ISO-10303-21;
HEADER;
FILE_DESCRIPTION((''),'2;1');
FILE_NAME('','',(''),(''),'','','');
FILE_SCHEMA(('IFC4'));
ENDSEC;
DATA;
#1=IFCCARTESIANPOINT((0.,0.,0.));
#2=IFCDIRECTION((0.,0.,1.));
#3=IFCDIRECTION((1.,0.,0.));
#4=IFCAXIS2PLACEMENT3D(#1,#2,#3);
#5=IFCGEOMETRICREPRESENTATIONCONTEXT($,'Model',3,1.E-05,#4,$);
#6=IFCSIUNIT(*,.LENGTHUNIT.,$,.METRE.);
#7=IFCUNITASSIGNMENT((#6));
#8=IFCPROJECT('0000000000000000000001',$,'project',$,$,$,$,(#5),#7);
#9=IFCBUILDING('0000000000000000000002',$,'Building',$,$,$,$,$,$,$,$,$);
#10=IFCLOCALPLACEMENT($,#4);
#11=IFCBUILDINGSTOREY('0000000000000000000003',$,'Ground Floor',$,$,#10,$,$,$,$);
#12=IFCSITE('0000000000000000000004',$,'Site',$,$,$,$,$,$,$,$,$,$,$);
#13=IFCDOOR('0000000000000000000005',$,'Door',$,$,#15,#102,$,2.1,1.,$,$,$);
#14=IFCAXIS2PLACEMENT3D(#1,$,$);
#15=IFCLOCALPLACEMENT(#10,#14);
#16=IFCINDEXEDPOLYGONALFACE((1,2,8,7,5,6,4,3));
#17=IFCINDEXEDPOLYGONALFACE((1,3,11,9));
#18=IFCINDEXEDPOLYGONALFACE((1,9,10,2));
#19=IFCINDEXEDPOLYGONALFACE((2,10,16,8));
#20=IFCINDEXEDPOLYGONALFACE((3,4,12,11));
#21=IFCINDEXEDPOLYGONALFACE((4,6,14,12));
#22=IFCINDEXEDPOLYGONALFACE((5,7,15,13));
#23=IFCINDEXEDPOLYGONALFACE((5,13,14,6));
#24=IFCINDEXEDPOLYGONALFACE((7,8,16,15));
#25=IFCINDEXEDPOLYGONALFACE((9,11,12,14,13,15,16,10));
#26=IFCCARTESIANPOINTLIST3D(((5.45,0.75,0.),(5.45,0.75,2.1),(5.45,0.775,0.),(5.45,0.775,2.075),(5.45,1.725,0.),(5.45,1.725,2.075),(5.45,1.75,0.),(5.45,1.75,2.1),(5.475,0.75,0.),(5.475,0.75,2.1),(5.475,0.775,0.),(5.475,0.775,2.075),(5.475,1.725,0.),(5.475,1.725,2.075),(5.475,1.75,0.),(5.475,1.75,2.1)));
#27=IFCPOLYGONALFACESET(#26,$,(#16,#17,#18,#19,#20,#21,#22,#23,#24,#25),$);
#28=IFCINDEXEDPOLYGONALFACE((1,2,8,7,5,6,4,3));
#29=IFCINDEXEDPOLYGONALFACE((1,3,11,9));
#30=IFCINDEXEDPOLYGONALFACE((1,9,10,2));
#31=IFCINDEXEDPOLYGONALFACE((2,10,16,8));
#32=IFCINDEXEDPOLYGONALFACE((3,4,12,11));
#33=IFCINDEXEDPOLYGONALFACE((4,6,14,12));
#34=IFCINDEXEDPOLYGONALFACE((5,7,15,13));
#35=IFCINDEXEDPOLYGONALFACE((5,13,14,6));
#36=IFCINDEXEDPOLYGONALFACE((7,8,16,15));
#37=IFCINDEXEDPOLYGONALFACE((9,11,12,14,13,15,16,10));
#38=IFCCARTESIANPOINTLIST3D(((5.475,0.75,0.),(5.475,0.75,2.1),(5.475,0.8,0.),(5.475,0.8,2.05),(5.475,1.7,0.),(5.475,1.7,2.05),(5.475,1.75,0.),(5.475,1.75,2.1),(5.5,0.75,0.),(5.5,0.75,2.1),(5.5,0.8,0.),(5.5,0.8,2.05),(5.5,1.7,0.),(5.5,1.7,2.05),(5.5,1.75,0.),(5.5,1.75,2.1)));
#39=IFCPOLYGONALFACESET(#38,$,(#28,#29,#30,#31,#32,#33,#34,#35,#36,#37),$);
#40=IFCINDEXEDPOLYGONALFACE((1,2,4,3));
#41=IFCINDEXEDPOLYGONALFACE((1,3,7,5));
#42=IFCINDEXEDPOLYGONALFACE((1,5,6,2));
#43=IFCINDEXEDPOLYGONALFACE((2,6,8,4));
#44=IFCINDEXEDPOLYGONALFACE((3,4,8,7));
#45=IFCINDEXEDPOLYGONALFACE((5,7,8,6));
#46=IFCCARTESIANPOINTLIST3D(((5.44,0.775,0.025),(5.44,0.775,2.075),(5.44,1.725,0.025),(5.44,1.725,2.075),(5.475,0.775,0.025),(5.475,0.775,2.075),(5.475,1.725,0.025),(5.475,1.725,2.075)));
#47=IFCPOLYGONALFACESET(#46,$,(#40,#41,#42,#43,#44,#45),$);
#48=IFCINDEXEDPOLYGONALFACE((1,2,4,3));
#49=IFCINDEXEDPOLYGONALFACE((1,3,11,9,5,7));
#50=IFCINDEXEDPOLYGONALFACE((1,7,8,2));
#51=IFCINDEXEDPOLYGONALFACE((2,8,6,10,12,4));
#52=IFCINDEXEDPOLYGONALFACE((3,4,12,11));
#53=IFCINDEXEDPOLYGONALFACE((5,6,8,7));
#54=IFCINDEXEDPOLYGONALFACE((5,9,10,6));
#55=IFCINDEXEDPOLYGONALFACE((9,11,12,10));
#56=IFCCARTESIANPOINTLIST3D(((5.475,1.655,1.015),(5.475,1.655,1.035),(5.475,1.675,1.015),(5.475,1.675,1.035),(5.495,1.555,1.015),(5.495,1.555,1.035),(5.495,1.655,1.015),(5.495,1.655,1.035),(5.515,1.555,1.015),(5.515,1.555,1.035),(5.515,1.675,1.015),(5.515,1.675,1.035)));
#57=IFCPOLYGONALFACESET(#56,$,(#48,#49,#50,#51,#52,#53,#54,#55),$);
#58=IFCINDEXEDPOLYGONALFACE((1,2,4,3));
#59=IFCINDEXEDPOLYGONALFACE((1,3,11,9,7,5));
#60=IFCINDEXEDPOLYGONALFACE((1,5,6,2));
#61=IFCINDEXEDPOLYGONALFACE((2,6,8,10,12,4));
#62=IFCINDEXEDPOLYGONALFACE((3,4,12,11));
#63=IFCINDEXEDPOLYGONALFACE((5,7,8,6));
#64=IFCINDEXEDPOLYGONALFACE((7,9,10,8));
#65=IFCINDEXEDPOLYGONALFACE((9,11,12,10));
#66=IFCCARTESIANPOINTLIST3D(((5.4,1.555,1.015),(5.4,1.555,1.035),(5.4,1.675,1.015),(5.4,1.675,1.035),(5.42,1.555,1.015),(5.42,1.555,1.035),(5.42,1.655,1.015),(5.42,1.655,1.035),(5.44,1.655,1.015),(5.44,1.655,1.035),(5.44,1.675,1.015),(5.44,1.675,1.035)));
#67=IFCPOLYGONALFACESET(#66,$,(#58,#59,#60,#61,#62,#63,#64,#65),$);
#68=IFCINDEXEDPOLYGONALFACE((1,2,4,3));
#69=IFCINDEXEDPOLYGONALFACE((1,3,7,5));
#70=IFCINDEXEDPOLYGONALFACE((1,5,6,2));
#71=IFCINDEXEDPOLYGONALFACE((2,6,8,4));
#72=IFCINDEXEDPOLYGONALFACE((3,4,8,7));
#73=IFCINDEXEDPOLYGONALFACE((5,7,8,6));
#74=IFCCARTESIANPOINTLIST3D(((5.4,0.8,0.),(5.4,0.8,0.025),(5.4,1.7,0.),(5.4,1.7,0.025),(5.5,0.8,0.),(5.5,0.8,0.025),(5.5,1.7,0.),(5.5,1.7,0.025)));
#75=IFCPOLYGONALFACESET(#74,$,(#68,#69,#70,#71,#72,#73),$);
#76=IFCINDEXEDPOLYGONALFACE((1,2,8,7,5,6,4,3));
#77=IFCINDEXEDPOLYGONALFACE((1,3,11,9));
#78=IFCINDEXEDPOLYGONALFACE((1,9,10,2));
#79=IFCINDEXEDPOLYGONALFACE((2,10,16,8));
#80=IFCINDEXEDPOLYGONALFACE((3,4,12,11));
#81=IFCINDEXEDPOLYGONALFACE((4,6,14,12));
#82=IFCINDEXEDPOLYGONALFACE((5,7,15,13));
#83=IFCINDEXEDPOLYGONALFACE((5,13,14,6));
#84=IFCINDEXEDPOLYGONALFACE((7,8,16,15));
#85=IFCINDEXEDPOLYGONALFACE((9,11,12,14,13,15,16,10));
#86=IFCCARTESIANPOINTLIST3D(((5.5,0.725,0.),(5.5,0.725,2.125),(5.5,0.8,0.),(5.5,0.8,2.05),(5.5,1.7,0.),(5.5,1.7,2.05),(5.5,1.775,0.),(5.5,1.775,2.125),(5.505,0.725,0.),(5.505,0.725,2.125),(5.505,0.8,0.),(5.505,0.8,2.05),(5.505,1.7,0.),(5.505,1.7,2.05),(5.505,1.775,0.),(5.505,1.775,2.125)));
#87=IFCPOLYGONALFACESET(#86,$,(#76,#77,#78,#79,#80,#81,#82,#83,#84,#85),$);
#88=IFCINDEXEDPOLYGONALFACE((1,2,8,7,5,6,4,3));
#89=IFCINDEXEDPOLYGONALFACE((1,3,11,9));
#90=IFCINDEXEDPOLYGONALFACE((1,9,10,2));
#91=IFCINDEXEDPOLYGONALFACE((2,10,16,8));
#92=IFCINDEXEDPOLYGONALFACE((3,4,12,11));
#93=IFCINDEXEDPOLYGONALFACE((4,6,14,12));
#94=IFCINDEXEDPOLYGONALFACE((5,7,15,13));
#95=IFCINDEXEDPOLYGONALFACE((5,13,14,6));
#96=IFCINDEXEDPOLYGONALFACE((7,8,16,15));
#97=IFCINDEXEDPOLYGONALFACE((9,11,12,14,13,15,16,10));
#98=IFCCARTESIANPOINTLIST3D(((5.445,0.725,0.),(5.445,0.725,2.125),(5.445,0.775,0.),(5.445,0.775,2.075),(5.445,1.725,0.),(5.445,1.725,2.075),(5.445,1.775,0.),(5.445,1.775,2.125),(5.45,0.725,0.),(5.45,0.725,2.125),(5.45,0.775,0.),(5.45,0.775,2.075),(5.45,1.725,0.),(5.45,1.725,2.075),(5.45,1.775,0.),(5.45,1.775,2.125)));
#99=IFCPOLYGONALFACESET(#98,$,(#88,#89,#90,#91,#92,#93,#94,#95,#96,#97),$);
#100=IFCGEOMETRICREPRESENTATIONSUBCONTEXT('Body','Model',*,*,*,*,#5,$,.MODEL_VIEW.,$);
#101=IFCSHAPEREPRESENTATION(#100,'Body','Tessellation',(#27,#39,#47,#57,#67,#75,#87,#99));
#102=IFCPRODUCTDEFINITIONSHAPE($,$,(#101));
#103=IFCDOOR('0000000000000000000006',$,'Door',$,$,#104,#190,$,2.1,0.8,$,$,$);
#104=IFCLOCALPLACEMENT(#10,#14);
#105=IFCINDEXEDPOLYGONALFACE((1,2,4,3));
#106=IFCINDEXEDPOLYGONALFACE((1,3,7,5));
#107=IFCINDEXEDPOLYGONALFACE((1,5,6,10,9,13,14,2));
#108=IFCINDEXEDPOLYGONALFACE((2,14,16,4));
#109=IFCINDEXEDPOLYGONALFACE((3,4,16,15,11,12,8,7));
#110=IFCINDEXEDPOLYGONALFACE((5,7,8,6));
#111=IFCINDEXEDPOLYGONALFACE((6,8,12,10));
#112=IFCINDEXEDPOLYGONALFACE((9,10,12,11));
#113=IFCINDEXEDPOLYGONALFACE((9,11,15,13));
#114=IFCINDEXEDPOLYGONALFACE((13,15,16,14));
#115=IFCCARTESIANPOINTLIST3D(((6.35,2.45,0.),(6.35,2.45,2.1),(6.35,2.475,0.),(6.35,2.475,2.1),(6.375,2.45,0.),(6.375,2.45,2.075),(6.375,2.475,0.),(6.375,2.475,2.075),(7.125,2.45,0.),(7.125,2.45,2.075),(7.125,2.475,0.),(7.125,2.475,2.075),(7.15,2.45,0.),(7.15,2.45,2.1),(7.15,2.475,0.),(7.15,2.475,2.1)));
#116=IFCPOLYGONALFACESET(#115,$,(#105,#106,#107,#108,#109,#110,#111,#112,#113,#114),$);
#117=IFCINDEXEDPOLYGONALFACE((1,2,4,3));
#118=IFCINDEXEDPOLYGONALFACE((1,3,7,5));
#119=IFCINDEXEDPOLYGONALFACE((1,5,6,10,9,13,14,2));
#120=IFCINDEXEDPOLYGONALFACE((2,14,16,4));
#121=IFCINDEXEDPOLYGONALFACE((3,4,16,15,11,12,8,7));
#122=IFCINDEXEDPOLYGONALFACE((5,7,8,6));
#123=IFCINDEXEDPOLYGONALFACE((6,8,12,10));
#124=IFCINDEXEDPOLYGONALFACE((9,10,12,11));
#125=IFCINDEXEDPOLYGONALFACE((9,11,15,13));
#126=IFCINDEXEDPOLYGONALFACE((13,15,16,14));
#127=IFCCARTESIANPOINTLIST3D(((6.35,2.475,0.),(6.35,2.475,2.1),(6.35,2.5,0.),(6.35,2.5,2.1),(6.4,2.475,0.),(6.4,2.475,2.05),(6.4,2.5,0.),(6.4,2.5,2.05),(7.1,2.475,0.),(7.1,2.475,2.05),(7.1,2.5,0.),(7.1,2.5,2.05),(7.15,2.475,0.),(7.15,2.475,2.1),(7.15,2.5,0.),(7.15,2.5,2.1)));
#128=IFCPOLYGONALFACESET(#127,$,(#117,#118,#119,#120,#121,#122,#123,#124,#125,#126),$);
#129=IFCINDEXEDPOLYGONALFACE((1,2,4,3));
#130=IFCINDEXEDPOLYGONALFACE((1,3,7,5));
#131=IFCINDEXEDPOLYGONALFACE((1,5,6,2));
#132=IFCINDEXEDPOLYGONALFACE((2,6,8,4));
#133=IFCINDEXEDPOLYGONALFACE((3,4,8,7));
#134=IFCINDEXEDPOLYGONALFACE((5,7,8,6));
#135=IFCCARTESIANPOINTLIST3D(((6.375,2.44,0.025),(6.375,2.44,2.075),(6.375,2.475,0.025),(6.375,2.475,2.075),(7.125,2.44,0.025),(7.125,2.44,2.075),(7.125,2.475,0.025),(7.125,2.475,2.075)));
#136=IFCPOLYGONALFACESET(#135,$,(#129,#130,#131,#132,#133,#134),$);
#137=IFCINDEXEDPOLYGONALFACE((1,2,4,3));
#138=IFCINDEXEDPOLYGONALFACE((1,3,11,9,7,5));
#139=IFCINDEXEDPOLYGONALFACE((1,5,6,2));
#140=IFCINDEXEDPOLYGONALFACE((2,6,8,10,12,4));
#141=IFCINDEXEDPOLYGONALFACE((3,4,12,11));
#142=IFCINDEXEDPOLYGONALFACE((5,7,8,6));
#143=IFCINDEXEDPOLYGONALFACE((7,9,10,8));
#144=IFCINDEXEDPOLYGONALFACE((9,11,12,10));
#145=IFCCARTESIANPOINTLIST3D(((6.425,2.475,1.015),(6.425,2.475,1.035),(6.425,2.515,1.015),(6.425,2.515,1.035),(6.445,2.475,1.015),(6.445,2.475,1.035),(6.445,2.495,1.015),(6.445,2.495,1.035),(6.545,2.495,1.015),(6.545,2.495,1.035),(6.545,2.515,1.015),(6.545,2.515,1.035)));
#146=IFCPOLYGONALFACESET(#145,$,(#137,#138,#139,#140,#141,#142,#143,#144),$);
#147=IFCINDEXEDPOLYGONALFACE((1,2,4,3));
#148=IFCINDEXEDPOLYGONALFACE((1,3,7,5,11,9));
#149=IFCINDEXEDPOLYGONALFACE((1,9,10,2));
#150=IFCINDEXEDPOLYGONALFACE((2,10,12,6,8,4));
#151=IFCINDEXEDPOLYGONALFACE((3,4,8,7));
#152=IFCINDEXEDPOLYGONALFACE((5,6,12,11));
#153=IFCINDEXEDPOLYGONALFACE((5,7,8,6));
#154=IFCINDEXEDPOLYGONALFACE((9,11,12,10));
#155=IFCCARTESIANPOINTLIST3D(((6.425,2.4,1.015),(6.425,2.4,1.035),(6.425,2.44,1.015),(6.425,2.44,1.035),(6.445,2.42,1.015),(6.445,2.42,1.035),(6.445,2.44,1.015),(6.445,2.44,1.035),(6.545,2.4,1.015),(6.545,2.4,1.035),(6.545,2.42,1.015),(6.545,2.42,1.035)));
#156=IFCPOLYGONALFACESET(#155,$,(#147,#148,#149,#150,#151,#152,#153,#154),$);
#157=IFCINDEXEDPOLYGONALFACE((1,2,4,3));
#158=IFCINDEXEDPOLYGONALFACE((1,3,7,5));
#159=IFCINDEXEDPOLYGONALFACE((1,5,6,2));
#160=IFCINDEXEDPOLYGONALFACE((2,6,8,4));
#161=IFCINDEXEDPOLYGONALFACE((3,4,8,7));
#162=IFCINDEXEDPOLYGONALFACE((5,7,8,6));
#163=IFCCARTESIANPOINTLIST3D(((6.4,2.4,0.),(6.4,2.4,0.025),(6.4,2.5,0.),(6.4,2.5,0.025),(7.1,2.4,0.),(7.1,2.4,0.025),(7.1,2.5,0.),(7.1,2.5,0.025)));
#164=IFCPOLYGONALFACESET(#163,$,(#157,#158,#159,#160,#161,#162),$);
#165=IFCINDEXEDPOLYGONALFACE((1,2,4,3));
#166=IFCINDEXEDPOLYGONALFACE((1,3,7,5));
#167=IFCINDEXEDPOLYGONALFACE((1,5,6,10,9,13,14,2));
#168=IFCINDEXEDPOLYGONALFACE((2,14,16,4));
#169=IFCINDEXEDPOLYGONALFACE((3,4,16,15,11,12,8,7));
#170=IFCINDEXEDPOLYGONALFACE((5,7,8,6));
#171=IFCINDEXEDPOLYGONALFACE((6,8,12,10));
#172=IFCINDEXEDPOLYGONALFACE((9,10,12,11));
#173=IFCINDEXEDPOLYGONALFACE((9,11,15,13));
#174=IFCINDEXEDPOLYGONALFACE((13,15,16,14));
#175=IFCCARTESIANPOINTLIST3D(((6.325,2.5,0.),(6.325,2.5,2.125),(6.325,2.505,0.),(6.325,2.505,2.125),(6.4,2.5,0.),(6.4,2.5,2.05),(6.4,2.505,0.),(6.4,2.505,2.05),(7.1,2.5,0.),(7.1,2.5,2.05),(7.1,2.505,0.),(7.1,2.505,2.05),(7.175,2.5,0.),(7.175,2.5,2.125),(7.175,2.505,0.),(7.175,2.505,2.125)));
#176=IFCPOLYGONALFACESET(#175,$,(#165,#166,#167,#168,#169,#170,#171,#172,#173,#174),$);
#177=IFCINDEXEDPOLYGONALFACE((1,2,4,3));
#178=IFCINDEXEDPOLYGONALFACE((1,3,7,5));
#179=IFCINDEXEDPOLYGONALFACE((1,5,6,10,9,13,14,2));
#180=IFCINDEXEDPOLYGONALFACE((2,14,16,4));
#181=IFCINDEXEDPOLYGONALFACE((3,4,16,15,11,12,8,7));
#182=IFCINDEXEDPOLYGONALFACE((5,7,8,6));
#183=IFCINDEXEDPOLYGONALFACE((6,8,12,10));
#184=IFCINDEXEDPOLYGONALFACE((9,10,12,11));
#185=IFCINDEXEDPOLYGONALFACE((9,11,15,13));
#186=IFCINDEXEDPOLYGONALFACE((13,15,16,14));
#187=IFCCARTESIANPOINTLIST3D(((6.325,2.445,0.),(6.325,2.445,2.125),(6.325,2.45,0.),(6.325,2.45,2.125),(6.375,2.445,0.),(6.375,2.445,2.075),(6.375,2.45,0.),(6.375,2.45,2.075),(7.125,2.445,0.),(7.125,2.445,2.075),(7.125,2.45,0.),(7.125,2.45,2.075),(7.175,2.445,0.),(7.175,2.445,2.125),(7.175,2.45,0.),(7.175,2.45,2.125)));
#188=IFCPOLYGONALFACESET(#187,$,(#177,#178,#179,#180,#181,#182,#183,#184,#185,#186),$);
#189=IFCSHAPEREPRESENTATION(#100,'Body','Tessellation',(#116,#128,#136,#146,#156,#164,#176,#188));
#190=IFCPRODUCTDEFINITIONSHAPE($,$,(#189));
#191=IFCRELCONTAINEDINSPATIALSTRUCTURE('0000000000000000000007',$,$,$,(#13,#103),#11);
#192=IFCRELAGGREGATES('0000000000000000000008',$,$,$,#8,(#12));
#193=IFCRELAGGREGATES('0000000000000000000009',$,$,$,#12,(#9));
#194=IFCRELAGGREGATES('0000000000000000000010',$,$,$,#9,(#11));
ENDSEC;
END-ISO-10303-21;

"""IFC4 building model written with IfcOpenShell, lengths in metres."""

from ifc_helpers import new_model, si_unit, frame, origin_with_axes, place, context, subcontext, project, spatial, line, indexed_curve, outline, extrude, element, save


model = new_model("IFC4")

# Units and contexts
model_context = context("Model", 3, precision=1e-05, world=origin_with_axes())
body_context = subcontext(model_context, "Body", "Model", "MODEL_VIEW")
ifc_project = project(units=[si_unit("LENGTHUNIT", "METRE")], contexts=[model_context])

# Site, building, storey
site = spatial("IfcSite", under=ifc_project, Name="Site")
building = spatial("IfcBuilding", under=site, Name="Building")
storey_placement = place(None, origin_with_axes())
storey = spatial("IfcBuildingStorey", under=building, at=storey_placement, Name="Ground Floor")

# Doors
door_1_placement = place(storey_placement, frame((5.5, 0.75, 0.0), z_axis=(0.0, 0.0, 1.0), x_axis=(0.0, 1.0, 0.0)))
element("IfcDoor", 1, at=door_1_placement, inside=storey, Name="Door", OverallHeight=2.1, OverallWidth=1.0, context=body_context, shape_type="SweptSolid", body=[
    extrude(outline(indexed_curve([(0.0, 0.0), (0.0, 2.1), (1.0, 2.1), (1.0, 0.0), (0.975, 0.0), (0.975, 2.075), (0.025, 2.075), (0.025, 0.0)], segments=[line(1, 2, 3, 4, 5, 6, 7, 8, 1)])), frame((0.0, 0.025, 0.0), z_axis=(0.0, -1.0, 0.0), x_axis=(1.0, 0.0, 0.0)), (0.0, 0.0, -1.0), 0.025),
    extrude(outline(indexed_curve([(0.0, 0.0), (0.0, 2.1), (1.0, 2.1), (1.0, 0.0), (0.95, 0.0), (0.95, 2.05), (0.05, 2.05), (0.05, 0.0)], segments=[line(1, 2, 3, 4, 5, 6, 7, 8, 1)])), frame((0.0, 0.0, 0.0), z_axis=(0.0, -1.0, 0.0), x_axis=(1.0, 0.0, 0.0)), (0.0, 0.0, -1.0), 0.025),
    extrude(outline(indexed_curve([(0.0, 0.0), (0.95, 0.0), (0.95, 0.035), (0.0, 0.035)], segments=[line(1, 2, 3, 4, 1)])), frame((0.025, 0.025, 0.025), z_axis=(0.0, 0.0, 1.0), x_axis=(1.0, 0.0, 0.0)), (0.0, 0.0, 1.0), 2.05),
    extrude(outline(indexed_curve([(0.0, 0.0), (0.0, -0.04), (-0.12, -0.04), (-0.12, -0.02), (-0.02, -0.02), (-0.02, 0.0)], segments=[line(1, 2, 3, 4, 5, 6, 1)])), frame((0.925, 0.025, 1.015), z_axis=(0.0, 0.0, 1.0), x_axis=(1.0, 0.0, 0.0)), (0.0, 0.0, 1.0), 0.02),
    extrude(outline(indexed_curve([(0.0, 0.0), (0.0, 0.04), (-0.12, 0.04), (-0.12, 0.02), (-0.02, 0.02), (-0.02, 0.0)], segments=[line(1, 2, 3, 4, 5, 6, 1)])), frame((0.925, 0.06, 1.015), z_axis=(0.0, 0.0, 1.0), x_axis=(1.0, 0.0, 0.0)), (0.0, 0.0, 1.0), 0.02),
    extrude(outline(indexed_curve([(0.0, 0.0), (0.9, 0.0), (0.9, 0.1), (0.0, 0.1)], segments=[line(1, 2, 3, 4, 1)])), frame((0.05, 0.0, 0.0), z_axis=(0.0, 0.0, 1.0), x_axis=(1.0, 0.0, 0.0)), (0.0, 0.0, 1.0), 0.025),
    extrude(outline(indexed_curve([(0.0, 0.0), (0.0, 2.125), (1.05, 2.125), (1.05, 0.0), (0.975, 0.0), (0.975, 2.05), (0.075, 2.05), (0.075, 0.0)], segments=[line(1, 2, 3, 4, 5, 6, 7, 8, 1)])), frame((-0.025, -0.005, 0.0), z_axis=(0.0, -1.0, 0.0), x_axis=(1.0, 0.0, 0.0)), (0.0, 0.0, -1.0), 0.005),
    extrude(outline(indexed_curve([(0.0, 0.0), (0.0, 2.125), (1.05, 2.125), (1.05, 0.0), (1.0, 0.0), (1.0, 2.075), (0.05, 2.075), (0.05, 0.0)], segments=[line(1, 2, 3, 4, 5, 6, 7, 8, 1)])), frame((-0.025, 0.05, 0.0), z_axis=(0.0, -1.0, 0.0), x_axis=(1.0, 0.0, 0.0)), (0.0, 0.0, -1.0), 0.005),
])
door_2_placement = place(storey_placement, frame((7.15, 2.5, 0.0), z_axis=(0.0, 0.0, 1.0), x_axis=(-1.0, 0.0, 0.0)))
element("IfcDoor", 2, at=door_2_placement, inside=storey, Name="Door", OverallHeight=2.1, OverallWidth=0.8, context=body_context, shape_type="SweptSolid", body=[
    extrude(outline(indexed_curve([(0.0, 0.0), (0.0, 2.1), (0.8, 2.1), (0.8, 0.0), (0.775, 0.0), (0.775, 2.075), (0.025, 2.075), (0.025, 0.0)], segments=[line(1, 2, 3, 4, 5, 6, 7, 8, 1)])), frame((0.0, 0.025, 0.0), z_axis=(0.0, -1.0, 0.0), x_axis=(1.0, 0.0, 0.0)), (0.0, 0.0, -1.0), 0.025),
    extrude(outline(indexed_curve([(0.0, 0.0), (0.0, 2.1), (0.8, 2.1), (0.8, 0.0), (0.75, 0.0), (0.75, 2.05), (0.05, 2.05), (0.05, 0.0)], segments=[line(1, 2, 3, 4, 5, 6, 7, 8, 1)])), frame((0.0, 0.0, 0.0), z_axis=(0.0, -1.0, 0.0), x_axis=(1.0, 0.0, 0.0)), (0.0, 0.0, -1.0), 0.025),
    extrude(outline(indexed_curve([(0.0, 0.0), (0.75, 0.0), (0.75, 0.035), (0.0, 0.035)], segments=[line(1, 2, 3, 4, 1)])), frame((0.025, 0.025, 0.025), z_axis=(0.0, 0.0, 1.0), x_axis=(1.0, 0.0, 0.0)), (0.0, 0.0, 1.0), 2.05),
    extrude(outline(indexed_curve([(0.0, 0.0), (0.0, -0.04), (-0.12, -0.04), (-0.12, -0.02), (-0.02, -0.02), (-0.02, 0.0)], segments=[line(1, 2, 3, 4, 5, 6, 1)])), frame((0.725, 0.025, 1.015), z_axis=(0.0, 0.0, 1.0), x_axis=(1.0, 0.0, 0.0)), (0.0, 0.0, 1.0), 0.02),
    extrude(outline(indexed_curve([(0.0, 0.0), (0.0, 0.04), (-0.12, 0.04), (-0.12, 0.02), (-0.02, 0.02), (-0.02, 0.0)], segments=[line(1, 2, 3, 4, 5, 6, 1)])), frame((0.725, 0.06, 1.015), z_axis=(0.0, 0.0, 1.0), x_axis=(1.0, 0.0, 0.0)), (0.0, 0.0, 1.0), 0.02),
    extrude(outline(indexed_curve([(0.0, 0.0), (0.7, 0.0), (0.7, 0.1), (0.0, 0.1)], segments=[line(1, 2, 3, 4, 1)])), frame((0.05, 0.0, 0.0), z_axis=(0.0, 0.0, 1.0), x_axis=(1.0, 0.0, 0.0)), (0.0, 0.0, 1.0), 0.025),
    extrude(outline(indexed_curve([(0.0, 0.0), (0.0, 2.125), (0.85, 2.125), (0.85, 0.0), (0.775, 0.0), (0.775, 2.05), (0.075, 2.05), (0.075, 0.0)], segments=[line(1, 2, 3, 4, 5, 6, 7, 8, 1)])), frame((-0.025, -0.005, 0.0), z_axis=(0.0, -1.0, 0.0), x_axis=(1.0, 0.0, 0.0)), (0.0, 0.0, -1.0), 0.005),
    extrude(outline(indexed_curve([(0.0, 0.0), (0.0, 2.125), (0.85, 2.125), (0.85, 0.0), (0.8, 0.0), (0.8, 2.075), (0.05, 2.075), (0.05, 0.0)], segments=[line(1, 2, 3, 4, 5, 6, 7, 8, 1)])), frame((-0.025, 0.05, 0.0), z_axis=(0.0, -1.0, 0.0), x_axis=(1.0, 0.0, 0.0)), (0.0, 0.0, -1.0), 0.005),
])

save(model, "model.ifc")
